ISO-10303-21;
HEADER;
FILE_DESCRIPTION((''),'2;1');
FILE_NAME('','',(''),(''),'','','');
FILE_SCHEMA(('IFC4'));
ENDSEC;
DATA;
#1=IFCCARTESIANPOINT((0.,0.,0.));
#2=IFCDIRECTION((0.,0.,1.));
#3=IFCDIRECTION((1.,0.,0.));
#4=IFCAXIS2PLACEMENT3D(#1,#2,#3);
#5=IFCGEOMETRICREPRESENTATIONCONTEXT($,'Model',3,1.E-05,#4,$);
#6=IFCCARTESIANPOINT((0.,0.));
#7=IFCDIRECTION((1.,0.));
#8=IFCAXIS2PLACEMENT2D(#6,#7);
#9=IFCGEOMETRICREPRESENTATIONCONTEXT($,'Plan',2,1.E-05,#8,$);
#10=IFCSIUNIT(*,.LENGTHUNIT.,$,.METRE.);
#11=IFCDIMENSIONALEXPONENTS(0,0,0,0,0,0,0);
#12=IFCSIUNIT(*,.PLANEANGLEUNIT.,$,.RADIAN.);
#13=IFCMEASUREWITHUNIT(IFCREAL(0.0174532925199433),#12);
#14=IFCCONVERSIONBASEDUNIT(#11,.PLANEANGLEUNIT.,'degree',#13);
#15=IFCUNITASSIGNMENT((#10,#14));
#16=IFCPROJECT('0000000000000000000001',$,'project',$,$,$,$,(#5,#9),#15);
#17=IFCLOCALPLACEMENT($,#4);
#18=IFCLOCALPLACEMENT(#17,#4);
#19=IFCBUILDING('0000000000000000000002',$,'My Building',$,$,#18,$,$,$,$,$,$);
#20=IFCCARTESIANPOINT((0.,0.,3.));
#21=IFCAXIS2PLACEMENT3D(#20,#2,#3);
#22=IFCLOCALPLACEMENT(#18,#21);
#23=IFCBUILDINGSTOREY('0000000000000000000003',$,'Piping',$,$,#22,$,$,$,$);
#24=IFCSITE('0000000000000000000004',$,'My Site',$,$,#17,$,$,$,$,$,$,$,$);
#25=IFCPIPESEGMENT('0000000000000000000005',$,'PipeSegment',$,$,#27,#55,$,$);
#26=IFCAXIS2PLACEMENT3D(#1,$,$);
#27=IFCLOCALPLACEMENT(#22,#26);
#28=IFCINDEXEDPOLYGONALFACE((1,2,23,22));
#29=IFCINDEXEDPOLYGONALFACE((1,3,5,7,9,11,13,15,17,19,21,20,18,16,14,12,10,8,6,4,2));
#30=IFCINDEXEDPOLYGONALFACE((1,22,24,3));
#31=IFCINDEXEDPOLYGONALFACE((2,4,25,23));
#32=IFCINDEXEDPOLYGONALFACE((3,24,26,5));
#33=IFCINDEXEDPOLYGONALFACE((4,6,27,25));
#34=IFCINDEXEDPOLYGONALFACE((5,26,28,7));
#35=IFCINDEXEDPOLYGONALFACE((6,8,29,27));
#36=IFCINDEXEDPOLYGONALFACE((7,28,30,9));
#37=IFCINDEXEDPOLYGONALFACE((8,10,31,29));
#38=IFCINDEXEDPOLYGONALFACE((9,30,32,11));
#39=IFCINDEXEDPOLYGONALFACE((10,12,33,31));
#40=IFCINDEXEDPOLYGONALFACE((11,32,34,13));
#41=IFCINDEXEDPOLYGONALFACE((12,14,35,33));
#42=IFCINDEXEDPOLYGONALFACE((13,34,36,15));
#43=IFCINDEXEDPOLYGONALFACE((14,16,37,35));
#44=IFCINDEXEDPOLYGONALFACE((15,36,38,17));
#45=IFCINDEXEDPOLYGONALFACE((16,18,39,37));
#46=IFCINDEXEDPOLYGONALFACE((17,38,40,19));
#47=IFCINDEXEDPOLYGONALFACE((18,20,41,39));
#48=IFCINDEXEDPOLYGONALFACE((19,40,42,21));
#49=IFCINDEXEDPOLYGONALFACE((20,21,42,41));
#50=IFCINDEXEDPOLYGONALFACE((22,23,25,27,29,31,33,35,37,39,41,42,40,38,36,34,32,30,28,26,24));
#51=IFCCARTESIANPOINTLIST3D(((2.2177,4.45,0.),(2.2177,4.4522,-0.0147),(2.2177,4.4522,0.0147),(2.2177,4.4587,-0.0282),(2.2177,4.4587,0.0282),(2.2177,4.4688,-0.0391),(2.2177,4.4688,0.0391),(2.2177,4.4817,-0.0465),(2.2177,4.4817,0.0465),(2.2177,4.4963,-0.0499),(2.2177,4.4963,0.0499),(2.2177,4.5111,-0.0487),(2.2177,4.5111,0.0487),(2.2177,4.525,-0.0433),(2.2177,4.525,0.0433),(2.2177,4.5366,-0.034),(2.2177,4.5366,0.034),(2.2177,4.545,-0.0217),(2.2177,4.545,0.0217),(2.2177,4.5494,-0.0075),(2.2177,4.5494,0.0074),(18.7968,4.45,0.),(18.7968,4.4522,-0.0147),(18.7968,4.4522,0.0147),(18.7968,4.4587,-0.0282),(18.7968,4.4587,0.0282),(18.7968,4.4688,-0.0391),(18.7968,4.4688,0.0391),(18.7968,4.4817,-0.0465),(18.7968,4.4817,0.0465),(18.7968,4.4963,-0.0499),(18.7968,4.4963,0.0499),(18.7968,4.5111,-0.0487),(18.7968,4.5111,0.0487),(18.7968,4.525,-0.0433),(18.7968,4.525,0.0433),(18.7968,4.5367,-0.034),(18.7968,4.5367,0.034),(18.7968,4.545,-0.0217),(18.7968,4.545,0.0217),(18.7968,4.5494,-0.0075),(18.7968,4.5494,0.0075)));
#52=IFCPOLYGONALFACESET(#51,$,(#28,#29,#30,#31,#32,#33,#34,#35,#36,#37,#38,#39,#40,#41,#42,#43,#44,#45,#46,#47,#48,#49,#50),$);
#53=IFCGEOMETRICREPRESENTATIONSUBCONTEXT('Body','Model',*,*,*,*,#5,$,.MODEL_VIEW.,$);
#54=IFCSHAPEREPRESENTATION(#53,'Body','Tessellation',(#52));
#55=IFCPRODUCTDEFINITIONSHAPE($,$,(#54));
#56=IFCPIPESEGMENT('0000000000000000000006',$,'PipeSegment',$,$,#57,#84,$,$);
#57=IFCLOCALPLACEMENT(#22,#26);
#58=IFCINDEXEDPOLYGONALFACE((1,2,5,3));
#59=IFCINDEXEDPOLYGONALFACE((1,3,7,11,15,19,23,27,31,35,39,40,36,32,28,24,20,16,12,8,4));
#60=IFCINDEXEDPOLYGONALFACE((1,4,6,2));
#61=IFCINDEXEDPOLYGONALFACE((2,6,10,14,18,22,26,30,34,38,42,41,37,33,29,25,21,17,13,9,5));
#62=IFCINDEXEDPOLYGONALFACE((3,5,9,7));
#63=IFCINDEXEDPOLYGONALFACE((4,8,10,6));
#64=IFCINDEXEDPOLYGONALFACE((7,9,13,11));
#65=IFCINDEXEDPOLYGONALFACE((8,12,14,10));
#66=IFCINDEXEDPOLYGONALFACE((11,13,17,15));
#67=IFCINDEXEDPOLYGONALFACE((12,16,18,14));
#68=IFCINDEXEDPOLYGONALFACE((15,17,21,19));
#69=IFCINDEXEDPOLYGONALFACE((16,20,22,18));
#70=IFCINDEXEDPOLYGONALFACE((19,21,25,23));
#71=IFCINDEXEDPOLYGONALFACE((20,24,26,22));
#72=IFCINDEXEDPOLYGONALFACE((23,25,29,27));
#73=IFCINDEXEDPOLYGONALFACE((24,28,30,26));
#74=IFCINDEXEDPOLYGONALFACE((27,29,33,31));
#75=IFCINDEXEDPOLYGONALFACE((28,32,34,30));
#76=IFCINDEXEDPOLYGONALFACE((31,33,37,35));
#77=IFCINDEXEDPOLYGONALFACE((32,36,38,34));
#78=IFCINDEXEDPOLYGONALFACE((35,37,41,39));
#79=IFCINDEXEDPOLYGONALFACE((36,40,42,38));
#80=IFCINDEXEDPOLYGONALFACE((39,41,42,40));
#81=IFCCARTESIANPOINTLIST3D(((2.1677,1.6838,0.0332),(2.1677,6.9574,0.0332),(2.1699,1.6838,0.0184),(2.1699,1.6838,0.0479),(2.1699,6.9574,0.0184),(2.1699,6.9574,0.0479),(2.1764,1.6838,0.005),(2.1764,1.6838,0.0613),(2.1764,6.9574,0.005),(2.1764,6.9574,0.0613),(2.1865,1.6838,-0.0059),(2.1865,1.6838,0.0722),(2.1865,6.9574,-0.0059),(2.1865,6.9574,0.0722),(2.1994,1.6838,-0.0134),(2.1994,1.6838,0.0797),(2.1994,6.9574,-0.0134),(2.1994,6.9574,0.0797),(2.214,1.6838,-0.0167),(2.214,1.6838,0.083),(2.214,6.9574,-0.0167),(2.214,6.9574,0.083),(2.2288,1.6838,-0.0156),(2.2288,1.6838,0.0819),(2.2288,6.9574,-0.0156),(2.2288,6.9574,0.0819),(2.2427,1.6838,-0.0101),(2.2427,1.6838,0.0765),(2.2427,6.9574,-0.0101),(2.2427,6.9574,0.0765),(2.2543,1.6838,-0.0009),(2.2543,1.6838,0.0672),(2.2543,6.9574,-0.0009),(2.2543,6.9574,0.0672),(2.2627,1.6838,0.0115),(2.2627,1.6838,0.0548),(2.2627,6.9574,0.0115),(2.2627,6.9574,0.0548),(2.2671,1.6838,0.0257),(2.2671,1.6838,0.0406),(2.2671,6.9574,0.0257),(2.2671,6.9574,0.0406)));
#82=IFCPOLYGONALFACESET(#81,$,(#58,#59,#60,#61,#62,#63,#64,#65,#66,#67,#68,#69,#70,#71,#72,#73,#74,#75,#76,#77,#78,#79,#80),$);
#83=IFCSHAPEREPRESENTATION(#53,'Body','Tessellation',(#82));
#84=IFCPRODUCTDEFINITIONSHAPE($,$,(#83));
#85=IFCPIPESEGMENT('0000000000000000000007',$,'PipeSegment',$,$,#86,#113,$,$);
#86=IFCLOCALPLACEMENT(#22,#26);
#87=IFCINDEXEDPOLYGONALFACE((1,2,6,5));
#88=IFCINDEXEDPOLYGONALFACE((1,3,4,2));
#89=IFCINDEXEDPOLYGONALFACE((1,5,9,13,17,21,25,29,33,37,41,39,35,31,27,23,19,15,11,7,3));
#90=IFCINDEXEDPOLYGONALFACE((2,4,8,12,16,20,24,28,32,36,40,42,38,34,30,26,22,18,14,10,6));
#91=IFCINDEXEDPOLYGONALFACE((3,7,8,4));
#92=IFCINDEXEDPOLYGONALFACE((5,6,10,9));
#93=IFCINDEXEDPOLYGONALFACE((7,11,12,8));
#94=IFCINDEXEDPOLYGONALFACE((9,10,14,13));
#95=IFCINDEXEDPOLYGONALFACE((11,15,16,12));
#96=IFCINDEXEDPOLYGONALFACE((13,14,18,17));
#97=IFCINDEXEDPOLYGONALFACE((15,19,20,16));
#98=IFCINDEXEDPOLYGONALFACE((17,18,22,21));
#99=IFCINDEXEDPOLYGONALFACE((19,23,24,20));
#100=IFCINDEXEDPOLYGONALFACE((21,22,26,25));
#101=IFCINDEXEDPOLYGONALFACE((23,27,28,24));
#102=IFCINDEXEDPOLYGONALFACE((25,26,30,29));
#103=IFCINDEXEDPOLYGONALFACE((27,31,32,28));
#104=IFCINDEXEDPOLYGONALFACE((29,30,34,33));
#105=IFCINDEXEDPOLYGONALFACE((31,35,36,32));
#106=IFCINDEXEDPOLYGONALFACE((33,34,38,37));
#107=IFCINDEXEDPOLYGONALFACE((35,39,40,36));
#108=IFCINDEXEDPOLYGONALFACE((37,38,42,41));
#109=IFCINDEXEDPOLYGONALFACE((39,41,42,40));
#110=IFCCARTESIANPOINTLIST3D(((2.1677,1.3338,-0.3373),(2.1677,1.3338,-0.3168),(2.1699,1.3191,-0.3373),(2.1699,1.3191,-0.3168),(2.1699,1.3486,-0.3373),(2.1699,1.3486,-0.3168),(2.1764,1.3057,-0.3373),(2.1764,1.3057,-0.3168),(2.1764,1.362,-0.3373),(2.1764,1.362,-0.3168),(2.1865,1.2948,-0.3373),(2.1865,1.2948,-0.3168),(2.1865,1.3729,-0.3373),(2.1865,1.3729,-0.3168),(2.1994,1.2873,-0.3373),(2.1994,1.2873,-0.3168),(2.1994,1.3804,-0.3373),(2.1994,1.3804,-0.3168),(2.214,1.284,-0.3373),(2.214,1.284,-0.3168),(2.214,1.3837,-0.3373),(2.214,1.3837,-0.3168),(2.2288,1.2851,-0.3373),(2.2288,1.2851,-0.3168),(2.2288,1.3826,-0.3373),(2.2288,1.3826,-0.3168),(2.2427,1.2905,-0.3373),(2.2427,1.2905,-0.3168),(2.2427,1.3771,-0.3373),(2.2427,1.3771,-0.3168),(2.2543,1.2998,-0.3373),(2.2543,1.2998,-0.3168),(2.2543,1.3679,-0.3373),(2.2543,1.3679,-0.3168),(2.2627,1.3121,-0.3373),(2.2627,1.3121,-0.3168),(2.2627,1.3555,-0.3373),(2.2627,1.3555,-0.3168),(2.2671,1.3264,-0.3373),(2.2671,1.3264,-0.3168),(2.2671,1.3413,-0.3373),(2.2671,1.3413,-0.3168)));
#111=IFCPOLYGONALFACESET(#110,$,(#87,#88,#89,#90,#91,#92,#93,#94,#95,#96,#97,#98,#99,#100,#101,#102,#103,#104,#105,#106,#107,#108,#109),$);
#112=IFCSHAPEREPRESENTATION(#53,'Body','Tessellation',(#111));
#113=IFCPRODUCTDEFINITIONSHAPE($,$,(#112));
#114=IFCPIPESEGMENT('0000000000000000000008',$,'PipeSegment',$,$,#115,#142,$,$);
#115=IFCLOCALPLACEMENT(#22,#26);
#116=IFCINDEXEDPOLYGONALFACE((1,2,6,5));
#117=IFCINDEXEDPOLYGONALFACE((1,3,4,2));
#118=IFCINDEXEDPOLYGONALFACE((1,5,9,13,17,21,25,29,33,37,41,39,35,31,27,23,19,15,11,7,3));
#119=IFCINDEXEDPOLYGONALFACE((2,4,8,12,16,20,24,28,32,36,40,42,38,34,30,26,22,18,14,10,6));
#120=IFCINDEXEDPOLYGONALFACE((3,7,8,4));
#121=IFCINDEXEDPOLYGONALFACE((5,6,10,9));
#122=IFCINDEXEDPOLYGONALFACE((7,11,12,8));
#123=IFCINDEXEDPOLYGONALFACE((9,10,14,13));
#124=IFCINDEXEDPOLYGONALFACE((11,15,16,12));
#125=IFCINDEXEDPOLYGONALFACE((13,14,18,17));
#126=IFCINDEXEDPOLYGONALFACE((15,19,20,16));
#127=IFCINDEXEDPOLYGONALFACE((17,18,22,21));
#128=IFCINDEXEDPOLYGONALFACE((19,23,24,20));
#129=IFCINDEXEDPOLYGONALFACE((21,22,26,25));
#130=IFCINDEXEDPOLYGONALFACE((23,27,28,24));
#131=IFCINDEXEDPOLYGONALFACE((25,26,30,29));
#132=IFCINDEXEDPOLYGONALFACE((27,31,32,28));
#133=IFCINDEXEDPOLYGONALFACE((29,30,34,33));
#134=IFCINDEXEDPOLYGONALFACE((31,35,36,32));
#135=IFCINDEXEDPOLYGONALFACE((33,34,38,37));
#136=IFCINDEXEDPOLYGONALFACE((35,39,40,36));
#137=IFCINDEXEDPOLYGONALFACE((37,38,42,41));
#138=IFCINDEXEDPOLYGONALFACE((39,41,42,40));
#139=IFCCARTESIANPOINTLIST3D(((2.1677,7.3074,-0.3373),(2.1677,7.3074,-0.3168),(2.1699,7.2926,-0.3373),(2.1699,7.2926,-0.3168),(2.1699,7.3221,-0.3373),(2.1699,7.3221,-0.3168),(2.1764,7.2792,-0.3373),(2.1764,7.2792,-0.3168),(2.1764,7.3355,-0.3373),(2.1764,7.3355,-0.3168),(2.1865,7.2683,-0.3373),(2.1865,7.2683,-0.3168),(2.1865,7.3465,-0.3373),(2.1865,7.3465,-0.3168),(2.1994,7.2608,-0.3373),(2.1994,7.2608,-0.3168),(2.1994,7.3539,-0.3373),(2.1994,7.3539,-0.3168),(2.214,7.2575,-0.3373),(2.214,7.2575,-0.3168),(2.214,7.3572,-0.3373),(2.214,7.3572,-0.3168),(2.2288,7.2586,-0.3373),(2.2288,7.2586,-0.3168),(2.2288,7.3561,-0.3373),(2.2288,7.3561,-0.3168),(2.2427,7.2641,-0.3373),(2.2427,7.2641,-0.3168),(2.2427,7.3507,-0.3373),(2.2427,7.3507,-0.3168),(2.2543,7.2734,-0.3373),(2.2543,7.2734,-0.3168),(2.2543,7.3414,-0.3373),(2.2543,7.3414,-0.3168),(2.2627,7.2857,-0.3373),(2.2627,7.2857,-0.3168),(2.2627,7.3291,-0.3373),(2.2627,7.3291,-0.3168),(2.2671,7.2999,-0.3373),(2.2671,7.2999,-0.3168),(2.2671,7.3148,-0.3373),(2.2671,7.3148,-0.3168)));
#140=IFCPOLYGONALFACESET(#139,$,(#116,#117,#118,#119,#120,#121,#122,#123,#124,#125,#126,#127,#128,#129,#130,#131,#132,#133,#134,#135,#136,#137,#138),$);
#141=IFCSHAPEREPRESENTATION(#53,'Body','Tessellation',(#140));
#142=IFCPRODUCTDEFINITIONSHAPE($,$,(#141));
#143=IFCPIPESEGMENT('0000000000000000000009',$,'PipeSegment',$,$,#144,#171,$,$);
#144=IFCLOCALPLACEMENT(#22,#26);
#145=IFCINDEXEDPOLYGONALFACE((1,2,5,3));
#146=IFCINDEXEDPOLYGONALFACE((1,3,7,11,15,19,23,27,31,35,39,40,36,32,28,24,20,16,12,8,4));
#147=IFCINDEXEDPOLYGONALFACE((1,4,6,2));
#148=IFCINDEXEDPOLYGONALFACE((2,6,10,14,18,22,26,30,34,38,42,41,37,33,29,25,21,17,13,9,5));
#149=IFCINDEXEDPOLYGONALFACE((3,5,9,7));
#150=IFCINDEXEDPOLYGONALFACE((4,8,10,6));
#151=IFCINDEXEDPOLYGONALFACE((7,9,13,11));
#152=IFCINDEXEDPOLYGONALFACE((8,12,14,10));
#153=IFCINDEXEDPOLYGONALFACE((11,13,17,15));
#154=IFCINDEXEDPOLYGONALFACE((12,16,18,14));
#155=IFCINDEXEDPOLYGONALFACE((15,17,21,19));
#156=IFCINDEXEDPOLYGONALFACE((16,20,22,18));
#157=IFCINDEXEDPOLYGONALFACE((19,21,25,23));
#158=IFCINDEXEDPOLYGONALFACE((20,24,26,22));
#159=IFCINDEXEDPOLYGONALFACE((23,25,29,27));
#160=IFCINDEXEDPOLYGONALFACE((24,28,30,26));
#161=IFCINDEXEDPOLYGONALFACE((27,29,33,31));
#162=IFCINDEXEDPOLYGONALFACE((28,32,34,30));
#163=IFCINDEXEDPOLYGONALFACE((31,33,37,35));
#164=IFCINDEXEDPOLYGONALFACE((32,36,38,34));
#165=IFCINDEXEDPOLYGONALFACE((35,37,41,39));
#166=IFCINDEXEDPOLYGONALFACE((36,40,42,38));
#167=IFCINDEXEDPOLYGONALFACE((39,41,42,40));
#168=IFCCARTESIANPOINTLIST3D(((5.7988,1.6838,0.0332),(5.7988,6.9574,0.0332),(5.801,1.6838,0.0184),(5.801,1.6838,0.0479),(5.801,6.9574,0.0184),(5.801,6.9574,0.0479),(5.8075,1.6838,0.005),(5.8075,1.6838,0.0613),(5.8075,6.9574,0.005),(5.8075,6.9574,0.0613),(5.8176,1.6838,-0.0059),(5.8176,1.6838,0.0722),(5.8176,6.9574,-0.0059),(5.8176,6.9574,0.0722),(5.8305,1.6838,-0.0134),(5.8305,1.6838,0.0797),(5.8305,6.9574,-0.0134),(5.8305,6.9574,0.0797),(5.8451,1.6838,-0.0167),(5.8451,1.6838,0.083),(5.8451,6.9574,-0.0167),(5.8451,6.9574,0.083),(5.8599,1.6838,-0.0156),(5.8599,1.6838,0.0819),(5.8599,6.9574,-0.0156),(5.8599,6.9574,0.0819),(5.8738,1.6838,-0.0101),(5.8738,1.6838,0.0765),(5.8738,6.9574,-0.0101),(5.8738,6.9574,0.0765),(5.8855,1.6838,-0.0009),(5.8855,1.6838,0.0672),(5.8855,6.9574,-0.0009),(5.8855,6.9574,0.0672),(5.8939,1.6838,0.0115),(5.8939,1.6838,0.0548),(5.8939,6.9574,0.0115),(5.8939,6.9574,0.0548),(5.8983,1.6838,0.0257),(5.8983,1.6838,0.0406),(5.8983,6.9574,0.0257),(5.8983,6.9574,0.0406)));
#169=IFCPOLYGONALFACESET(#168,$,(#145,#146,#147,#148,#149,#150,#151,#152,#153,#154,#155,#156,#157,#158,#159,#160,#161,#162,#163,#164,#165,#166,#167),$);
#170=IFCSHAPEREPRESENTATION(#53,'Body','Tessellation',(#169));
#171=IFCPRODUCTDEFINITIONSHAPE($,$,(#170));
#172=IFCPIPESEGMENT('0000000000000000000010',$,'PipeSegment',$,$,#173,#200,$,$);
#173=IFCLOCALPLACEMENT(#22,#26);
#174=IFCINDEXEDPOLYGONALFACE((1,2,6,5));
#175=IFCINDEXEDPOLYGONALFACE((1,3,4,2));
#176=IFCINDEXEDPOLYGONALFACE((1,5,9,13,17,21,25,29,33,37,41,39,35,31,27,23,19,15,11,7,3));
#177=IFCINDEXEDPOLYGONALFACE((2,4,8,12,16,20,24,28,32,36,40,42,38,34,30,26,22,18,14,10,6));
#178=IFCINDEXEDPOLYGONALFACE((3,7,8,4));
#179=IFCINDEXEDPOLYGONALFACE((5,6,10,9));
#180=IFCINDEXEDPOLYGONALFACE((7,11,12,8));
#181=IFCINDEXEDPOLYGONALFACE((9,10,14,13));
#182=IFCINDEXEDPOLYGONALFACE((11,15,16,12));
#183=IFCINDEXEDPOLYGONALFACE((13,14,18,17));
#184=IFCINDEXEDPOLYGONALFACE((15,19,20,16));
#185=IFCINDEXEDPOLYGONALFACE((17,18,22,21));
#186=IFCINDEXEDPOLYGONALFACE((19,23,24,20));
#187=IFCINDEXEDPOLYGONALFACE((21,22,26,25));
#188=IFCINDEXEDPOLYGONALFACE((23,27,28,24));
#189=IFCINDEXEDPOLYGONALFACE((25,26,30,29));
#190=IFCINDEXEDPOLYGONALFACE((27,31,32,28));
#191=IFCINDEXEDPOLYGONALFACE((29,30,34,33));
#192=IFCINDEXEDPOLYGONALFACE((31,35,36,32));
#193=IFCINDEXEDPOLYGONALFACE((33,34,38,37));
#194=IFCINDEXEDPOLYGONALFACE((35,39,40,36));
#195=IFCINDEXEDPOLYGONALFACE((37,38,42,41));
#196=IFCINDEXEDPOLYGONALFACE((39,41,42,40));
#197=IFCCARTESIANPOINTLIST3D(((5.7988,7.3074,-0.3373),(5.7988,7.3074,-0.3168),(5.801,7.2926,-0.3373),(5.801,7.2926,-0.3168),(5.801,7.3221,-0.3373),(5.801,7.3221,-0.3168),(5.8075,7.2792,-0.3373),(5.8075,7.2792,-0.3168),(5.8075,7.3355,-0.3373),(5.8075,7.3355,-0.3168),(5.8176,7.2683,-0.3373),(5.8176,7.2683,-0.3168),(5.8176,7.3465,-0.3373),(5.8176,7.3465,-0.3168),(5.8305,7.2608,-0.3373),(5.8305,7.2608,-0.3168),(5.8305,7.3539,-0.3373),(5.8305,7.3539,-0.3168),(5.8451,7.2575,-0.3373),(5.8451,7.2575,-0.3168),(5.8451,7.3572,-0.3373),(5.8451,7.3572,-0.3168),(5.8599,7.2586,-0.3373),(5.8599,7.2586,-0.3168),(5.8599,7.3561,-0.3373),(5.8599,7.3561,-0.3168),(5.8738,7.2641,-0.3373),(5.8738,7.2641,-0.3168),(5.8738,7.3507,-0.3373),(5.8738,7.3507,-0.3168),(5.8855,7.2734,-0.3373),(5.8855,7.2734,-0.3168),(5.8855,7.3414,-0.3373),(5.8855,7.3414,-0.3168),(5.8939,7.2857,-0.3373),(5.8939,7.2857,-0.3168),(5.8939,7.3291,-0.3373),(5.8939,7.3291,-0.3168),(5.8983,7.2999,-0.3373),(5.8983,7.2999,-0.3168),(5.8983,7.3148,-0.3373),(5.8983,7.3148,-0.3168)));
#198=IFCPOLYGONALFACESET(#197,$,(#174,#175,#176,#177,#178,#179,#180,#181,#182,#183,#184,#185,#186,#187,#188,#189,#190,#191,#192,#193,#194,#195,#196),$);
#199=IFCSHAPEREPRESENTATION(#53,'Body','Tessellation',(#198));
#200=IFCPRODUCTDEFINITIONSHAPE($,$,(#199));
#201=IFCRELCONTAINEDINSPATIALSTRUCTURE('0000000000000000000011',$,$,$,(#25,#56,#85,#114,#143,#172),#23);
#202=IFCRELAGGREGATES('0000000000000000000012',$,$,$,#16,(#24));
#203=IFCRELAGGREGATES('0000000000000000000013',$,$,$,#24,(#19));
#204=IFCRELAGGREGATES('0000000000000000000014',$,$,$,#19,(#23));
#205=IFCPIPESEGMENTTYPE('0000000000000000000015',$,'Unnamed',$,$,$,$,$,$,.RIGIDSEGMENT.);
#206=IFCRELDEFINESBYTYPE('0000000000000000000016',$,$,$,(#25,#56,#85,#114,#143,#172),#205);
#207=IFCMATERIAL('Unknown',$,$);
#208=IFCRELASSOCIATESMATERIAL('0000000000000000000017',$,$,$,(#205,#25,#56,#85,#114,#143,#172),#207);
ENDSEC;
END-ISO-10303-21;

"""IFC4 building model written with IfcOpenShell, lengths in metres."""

from ifc_helpers import new_model, entity, si_unit, converted_unit, frame, origin_with_axes, origin_2d_with_axis, place, context, subcontext, project, spatial, circle, extrude, material, material_profile, profile_set, profile_usage, type_object, element, save


model = new_model("IFC4")

# Units and contexts
model_context = context("Model", 3, precision=1e-05, world=origin_with_axes())
plan_context = context("Plan", 2, precision=1e-05, world=origin_2d_with_axis())
body_context = subcontext(model_context, "Body", "Model", "MODEL_VIEW")
ifc_project = project(units=[si_unit("LENGTHUNIT", "METRE"), converted_unit("PLANEANGLEUNIT", "degree", entity("IfcReal", 0.0174532925199433), si_unit("PLANEANGLEUNIT", "RADIAN"), dimensions=[0, 0, 0, 0, 0, 0, 0])], contexts=[model_context, plan_context])

# Site, building, storey
site_placement = place(None, origin_with_axes())
site = spatial("IfcSite", under=ifc_project, at=site_placement, Name="My Site")
building_placement = place(site_placement, origin_with_axes())
building = spatial("IfcBuilding", under=site, at=building_placement, Name="My Building")
storey_placement = place(building_placement, frame((0.0, 0.0, 3.0), z_axis=(0.0, 0.0, 1.0), x_axis=(1.0, 0.0, 0.0)))
storey = spatial("IfcBuildingStorey", under=building, at=storey_placement, Name="Piping")

# Pipe segments
ifc_material = material(Name="Unknown")
ifc_material_profile = material_profile(ifc_material, circle(Radius=0.05))
ifc_profile_set = profile_set([ifc_material_profile])
ifc_profile_usage_1 = profile_usage(ifc_profile_set, cardinal=5)
pipe_segment_type = type_object("IfcPipeSegmentType", Name="Unnamed", PredefinedType="RIGIDSEGMENT", material=ifc_profile_set)
pipe_segment_1_placement = place(storey_placement, frame((18.7968, 4.5, 0.0), z_axis=(-1.0, 0.0, 0.0), x_axis=(0.0, -1.0, 0.0)))
element("IfcPipeSegment", 1, at=pipe_segment_1_placement, inside=storey, type_object=pipe_segment_type, material=ifc_profile_usage_1, Name="PipeSegment", context=body_context, shape_type="SweptSolid", body=[
    extrude(circle(Radius=0.05), origin_with_axes(), (0.0, 0.0, 1.0), 16.5791),
])
ifc_profile_usage_2 = profile_usage(ifc_profile_set, cardinal=5)
pipe_segment_2_placement = place(storey_placement, frame((2.2177, 1.6838, 0.0332), z_axis=(0.0, 1.0, 0.0), x_axis=(-1.0, 0.0, 0.0)))
element("IfcPipeSegment", 2, at=pipe_segment_2_placement, inside=storey, type_object=pipe_segment_type, material=ifc_profile_usage_2, Name="PipeSegment", context=body_context, shape_type="SweptSolid", body=[
    extrude(circle(Radius=0.05), origin_with_axes(), (0.0, 0.0, 1.0), 5.2735),
])
ifc_profile_usage_3 = profile_usage(ifc_profile_set, cardinal=5)
pipe_segment_3_placement = place(storey_placement, frame((2.2177, 1.3338, -0.3168), z_axis=(0.0, 0.0, -1.0), x_axis=(-1.0, 0.0, 0.0)))
element("IfcPipeSegment", 3, at=pipe_segment_3_placement, inside=storey, type_object=pipe_segment_type, material=ifc_profile_usage_3, Name="PipeSegment", context=body_context, shape_type="SweptSolid", body=[
    extrude(circle(Radius=0.05), origin_with_axes(), (0.0, 0.0, 1.0), 0.0204),
])
ifc_profile_usage_4 = profile_usage(ifc_profile_set, cardinal=5)
pipe_segment_4_placement = place(storey_placement, frame((2.2177, 7.3074, -0.3168), z_axis=(0.0, 0.0, -1.0), x_axis=(-1.0, 0.0, 0.0)))
element("IfcPipeSegment", 4, at=pipe_segment_4_placement, inside=storey, type_object=pipe_segment_type, material=ifc_profile_usage_4, Name="PipeSegment", context=body_context, shape_type="SweptSolid", body=[
    extrude(circle(Radius=0.05), origin_with_axes(), (0.0, 0.0, 1.0), 0.0204),
])
ifc_profile_usage_5 = profile_usage(ifc_profile_set, cardinal=5)
pipe_segment_5_placement = place(storey_placement, frame((5.8488, 1.6838, 0.0332), z_axis=(0.0, 1.0, 0.0), x_axis=(-1.0, 0.0, 0.0)))
element("IfcPipeSegment", 5, at=pipe_segment_5_placement, inside=storey, type_object=pipe_segment_type, material=ifc_profile_usage_5, Name="PipeSegment", context=body_context, shape_type="SweptSolid", body=[
    extrude(circle(Radius=0.05), origin_with_axes(), (0.0, 0.0, 1.0), 5.2735),
])
ifc_profile_usage_6 = profile_usage(ifc_profile_set, cardinal=5)
pipe_segment_6_placement = place(storey_placement, frame((5.8488, 7.3074, -0.3168), z_axis=(0.0, 0.0, -1.0), x_axis=(-1.0, 0.0, 0.0)))
element("IfcPipeSegment", 6, at=pipe_segment_6_placement, inside=storey, type_object=pipe_segment_type, material=ifc_profile_usage_6, Name="PipeSegment", context=body_context, shape_type="SweptSolid", body=[
    extrude(circle(Radius=0.05), origin_with_axes(), (0.0, 0.0, 1.0), 0.0204),
])

save(model, "model.ifc")
